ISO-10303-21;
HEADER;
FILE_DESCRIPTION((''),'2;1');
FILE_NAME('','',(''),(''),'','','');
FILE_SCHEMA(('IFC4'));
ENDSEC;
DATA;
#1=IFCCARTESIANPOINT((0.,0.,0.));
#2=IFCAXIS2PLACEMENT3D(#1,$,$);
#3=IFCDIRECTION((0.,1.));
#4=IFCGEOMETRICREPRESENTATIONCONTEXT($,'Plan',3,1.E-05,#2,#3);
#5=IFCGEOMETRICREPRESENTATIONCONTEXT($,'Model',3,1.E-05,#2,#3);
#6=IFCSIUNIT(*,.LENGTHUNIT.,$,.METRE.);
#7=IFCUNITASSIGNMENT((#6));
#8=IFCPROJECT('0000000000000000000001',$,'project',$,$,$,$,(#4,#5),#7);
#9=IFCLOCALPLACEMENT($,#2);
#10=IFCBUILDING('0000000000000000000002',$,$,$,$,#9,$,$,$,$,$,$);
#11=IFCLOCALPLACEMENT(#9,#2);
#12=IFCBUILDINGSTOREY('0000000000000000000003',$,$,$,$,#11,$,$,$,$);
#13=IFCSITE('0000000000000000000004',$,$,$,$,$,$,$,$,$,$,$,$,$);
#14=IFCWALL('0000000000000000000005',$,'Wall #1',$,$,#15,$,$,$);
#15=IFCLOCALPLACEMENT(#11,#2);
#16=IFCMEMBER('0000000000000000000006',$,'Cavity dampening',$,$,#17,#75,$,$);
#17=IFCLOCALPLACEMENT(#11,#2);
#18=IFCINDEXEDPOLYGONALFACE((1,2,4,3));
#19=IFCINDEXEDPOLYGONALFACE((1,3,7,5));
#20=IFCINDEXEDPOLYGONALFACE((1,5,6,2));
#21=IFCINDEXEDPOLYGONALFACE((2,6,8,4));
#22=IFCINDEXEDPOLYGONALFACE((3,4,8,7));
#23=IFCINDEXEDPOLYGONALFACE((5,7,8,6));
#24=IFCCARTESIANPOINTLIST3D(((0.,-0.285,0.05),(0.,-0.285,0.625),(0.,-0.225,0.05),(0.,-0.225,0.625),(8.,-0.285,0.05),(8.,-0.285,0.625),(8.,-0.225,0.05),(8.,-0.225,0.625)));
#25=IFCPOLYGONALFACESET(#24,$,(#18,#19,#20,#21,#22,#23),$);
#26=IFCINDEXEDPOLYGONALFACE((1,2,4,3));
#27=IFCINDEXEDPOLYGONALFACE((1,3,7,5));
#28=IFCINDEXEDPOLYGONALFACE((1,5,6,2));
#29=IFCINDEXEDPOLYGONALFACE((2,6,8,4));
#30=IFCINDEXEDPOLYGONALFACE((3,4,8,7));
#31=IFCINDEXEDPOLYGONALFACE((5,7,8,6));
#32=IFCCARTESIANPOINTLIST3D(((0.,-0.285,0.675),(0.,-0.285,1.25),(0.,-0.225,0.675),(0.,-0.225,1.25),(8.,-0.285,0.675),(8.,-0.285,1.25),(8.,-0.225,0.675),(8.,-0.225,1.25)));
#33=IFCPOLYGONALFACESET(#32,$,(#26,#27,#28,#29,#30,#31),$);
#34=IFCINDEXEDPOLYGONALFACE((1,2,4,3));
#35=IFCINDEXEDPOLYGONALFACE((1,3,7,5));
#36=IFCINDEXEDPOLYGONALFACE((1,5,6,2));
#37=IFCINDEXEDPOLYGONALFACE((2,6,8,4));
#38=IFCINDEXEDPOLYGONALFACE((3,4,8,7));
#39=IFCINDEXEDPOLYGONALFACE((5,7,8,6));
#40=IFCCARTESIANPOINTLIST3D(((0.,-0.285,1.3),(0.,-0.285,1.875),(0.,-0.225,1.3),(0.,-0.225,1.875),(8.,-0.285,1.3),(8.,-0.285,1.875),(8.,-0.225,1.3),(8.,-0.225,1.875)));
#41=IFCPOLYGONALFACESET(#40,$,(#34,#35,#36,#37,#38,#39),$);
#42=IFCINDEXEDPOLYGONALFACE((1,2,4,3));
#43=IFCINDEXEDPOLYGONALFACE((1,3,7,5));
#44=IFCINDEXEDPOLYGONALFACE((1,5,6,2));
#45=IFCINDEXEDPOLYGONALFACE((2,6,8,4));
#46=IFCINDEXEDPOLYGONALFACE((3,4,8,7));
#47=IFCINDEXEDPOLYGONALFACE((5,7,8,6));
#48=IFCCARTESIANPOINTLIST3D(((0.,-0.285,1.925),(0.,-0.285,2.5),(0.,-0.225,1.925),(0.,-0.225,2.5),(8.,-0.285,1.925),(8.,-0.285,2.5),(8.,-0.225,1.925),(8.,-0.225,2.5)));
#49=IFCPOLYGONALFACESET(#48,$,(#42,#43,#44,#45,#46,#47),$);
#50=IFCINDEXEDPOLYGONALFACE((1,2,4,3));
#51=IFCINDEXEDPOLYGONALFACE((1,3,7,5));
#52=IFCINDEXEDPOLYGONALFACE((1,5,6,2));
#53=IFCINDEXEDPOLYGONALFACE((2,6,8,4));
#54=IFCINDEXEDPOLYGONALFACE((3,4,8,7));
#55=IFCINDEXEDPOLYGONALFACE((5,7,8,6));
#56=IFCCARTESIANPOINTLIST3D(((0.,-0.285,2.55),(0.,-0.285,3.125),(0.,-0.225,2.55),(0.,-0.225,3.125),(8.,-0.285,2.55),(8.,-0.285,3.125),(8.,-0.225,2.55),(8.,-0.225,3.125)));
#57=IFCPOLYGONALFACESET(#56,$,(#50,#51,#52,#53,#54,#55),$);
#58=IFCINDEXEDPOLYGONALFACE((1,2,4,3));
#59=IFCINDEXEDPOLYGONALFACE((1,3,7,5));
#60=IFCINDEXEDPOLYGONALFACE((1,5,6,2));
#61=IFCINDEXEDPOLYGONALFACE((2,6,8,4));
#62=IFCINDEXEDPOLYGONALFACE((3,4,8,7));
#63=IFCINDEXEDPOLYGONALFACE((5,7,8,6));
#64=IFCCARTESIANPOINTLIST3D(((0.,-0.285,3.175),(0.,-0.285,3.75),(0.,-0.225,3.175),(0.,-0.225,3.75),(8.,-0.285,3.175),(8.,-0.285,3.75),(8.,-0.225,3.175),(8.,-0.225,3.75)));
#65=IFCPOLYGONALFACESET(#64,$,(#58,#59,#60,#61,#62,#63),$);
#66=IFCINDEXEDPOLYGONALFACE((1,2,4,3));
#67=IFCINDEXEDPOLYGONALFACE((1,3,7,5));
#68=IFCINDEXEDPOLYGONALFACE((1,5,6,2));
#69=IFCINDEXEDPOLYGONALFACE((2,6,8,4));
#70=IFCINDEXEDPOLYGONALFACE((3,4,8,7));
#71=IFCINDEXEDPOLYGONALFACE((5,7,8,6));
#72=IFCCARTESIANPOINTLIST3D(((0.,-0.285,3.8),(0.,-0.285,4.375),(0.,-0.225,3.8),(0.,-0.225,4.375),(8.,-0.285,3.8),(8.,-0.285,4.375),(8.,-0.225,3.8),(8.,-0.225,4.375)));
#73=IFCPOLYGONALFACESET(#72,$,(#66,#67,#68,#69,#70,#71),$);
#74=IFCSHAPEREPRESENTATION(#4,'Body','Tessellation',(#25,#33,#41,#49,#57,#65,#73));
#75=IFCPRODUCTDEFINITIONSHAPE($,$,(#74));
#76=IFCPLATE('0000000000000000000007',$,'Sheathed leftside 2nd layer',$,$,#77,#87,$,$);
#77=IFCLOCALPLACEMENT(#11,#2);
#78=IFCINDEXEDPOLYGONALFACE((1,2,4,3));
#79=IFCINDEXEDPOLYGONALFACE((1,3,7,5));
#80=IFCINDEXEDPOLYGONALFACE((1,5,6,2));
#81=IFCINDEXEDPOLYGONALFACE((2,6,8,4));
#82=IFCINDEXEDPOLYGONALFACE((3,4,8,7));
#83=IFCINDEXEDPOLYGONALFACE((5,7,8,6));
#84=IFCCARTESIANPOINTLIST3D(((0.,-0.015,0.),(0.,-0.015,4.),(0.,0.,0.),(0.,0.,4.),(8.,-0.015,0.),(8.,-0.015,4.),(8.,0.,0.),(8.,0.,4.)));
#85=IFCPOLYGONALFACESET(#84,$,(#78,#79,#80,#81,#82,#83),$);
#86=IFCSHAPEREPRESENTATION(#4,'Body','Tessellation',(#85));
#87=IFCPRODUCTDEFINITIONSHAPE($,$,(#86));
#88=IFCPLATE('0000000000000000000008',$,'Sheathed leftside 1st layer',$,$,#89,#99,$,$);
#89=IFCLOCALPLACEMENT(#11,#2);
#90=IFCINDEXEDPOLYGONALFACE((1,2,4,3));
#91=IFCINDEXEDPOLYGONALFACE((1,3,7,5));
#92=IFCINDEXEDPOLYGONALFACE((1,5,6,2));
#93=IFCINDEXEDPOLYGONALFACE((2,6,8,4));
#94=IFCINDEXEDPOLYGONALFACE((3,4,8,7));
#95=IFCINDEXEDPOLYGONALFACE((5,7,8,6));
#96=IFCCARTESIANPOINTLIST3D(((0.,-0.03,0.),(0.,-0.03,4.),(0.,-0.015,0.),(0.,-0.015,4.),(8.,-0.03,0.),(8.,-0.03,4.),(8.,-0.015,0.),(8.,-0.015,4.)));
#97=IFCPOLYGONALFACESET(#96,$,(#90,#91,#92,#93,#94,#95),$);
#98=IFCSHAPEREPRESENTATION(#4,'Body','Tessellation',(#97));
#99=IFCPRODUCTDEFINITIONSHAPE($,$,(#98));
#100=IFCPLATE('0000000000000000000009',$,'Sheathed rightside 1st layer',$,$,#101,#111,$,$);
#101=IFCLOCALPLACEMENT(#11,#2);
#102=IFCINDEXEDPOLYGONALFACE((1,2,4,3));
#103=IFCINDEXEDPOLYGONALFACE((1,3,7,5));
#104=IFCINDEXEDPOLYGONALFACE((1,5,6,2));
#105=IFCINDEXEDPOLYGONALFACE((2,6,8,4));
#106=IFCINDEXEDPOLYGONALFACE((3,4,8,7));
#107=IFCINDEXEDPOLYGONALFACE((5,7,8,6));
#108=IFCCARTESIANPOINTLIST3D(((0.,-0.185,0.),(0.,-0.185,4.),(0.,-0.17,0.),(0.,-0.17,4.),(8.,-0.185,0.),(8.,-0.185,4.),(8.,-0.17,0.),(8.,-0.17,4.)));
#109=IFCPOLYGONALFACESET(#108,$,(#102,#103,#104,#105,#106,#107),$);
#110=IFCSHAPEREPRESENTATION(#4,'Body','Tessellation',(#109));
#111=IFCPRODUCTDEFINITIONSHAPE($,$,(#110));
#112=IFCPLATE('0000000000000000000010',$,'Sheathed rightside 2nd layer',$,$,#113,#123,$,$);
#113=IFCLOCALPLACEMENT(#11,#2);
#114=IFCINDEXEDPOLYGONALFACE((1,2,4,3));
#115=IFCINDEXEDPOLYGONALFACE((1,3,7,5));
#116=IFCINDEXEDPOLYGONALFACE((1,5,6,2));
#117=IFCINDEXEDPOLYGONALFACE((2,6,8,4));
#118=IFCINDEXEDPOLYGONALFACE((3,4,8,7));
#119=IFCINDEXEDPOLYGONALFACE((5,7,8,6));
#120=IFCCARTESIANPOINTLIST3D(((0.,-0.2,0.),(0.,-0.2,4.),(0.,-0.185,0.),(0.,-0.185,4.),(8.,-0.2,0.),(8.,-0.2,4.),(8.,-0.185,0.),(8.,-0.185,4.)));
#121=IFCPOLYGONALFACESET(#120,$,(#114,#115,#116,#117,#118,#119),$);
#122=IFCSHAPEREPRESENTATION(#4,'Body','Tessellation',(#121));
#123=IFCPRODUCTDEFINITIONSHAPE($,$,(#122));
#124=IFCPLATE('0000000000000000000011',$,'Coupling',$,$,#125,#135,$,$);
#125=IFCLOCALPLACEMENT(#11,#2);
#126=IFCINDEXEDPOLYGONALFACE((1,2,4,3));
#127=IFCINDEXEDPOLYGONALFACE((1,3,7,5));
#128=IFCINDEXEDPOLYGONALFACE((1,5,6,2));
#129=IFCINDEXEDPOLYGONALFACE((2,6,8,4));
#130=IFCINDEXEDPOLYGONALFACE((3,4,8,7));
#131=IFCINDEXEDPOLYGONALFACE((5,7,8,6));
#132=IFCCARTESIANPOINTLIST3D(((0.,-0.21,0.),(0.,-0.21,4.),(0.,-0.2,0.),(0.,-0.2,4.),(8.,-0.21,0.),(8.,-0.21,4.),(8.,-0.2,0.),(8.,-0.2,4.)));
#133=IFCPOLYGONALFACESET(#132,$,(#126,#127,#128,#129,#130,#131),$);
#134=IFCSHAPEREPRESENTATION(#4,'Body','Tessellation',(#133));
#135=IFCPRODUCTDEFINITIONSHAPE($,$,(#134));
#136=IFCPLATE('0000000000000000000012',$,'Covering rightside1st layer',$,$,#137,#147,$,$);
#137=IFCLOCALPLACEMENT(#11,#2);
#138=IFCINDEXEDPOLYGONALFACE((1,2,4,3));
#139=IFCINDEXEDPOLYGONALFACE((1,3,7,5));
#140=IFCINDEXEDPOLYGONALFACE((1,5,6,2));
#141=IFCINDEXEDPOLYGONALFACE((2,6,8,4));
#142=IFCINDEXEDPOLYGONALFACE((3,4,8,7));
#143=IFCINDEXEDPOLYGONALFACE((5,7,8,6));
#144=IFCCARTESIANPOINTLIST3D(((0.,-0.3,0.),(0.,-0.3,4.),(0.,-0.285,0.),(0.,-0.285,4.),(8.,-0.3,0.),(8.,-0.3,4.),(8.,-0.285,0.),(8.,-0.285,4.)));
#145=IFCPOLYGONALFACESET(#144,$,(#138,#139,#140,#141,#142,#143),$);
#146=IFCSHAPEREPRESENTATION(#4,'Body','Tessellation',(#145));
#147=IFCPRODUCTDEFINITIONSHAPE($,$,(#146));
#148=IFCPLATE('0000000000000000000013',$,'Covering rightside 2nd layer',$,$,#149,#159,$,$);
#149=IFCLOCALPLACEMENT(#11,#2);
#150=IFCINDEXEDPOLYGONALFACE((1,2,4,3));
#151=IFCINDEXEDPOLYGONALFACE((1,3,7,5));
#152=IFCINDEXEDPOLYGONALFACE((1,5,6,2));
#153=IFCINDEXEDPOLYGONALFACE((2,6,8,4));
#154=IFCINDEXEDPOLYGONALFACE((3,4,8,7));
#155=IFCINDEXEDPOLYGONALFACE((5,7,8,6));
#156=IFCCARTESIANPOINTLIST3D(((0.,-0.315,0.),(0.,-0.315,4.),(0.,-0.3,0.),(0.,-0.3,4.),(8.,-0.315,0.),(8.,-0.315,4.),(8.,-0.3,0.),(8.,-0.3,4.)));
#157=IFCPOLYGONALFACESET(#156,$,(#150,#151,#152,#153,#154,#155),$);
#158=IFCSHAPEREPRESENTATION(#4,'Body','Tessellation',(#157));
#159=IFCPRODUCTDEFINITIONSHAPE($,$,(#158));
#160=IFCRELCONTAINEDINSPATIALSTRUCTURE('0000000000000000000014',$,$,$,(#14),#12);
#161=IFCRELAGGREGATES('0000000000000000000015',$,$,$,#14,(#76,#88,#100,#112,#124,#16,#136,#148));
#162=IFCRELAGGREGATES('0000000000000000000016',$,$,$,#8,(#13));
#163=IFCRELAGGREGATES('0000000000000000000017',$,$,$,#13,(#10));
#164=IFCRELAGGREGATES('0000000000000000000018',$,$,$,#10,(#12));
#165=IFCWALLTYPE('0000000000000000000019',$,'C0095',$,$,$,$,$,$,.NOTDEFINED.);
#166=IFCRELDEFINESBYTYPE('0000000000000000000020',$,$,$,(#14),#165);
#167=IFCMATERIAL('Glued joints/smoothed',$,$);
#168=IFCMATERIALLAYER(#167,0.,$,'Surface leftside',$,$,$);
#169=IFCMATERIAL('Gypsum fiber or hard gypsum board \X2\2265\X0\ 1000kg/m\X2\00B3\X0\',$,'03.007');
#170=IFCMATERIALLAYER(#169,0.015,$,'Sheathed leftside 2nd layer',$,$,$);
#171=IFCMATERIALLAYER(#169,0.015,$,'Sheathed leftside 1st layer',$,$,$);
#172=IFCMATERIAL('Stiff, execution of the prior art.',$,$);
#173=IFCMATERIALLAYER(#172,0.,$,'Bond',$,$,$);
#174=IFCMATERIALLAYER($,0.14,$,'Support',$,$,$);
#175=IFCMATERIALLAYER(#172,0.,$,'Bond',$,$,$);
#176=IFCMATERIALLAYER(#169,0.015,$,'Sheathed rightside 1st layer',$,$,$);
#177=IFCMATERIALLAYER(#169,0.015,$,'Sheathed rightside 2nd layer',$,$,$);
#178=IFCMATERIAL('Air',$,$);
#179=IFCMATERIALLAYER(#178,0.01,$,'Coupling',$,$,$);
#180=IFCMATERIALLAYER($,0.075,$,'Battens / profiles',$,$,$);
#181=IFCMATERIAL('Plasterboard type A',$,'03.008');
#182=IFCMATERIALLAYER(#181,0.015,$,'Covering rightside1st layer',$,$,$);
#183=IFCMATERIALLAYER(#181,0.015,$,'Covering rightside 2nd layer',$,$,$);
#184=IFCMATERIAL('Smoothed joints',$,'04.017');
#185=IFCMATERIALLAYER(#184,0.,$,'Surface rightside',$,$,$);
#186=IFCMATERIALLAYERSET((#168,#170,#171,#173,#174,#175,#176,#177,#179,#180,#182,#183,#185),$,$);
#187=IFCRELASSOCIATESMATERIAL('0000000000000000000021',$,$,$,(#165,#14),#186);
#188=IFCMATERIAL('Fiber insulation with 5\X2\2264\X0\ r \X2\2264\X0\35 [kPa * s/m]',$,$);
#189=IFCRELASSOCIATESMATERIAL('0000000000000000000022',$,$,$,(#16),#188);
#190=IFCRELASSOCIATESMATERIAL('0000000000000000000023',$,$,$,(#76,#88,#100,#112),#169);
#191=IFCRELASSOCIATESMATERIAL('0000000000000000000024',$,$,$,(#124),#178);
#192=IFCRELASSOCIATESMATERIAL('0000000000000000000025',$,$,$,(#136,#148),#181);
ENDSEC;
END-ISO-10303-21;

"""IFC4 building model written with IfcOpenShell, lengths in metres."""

from ifc_helpers import new_model, si_unit, direction, frame, frame_2d, origin, origin_with_axes, place, context, project, spatial, rectangle, extrude, material, layer, layer_set, type_object, element, aggregate, save


model = new_model("IFC4")

# Units and contexts
plan_context = context("Plan", 3, precision=1e-05, world=origin(), true_north=direction((0.0, 1.0)))
model_context = context("Model", 3, precision=1e-05, world=origin(), true_north=direction((0.0, 1.0)))
ifc_project = project(units=[si_unit("LENGTHUNIT", "METRE")], contexts=[plan_context, model_context])

# Site, building, storey
site = spatial("IfcSite", under=ifc_project)
building_placement = place(None, origin())
building = spatial("IfcBuilding", under=site, at=building_placement)
storey_placement = place(building_placement, origin())
storey = spatial("IfcBuildingStorey", under=building, at=storey_placement)

# Wall, member, plates
ifc_material_1 = material(Name="Glued joints/smoothed")
ifc_layer_1 = layer(ifc_material_1, 0.0, Name="Surface leftside")
ifc_material_2 = material(Name="Gypsum fiber or hard gypsum board ≥ 1000kg/m³", Category="03.007")
ifc_layer_2 = layer(ifc_material_2, 0.015, Name="Sheathed leftside 2nd layer")
ifc_layer_3 = layer(ifc_material_2, 0.015, Name="Sheathed leftside 1st layer")
ifc_material_3 = material(Name="Stiff, execution of the prior art.")
ifc_layer_4 = layer(ifc_material_3, 0.0, Name="Bond")
ifc_layer_5 = layer(None, 0.14, Name="Support")
ifc_layer_6 = layer(ifc_material_3, 0.0, Name="Bond")
ifc_layer_7 = layer(ifc_material_2, 0.015, Name="Sheathed rightside 1st layer")
ifc_layer_8 = layer(ifc_material_2, 0.015, Name="Sheathed rightside 2nd layer")
ifc_material_4 = material(Name="Air")
ifc_layer_9 = layer(ifc_material_4, 0.01, Name="Coupling")
ifc_layer_10 = layer(None, 0.075, Name="Battens / profiles")
ifc_material_5 = material(Name="Plasterboard type A", Category="03.008")
ifc_layer_11 = layer(ifc_material_5, 0.015, Name="Covering rightside1st layer")
ifc_layer_12 = layer(ifc_material_5, 0.015, Name="Covering rightside 2nd layer")
ifc_material_6 = material(Name="Smoothed joints", Category="04.017")
ifc_layer_13 = layer(ifc_material_6, 0.0, Name="Surface rightside")
ifc_layer_set = layer_set([ifc_layer_1, ifc_layer_2, ifc_layer_3, ifc_layer_4, ifc_layer_5, ifc_layer_6, ifc_layer_7, ifc_layer_8, ifc_layer_9, ifc_layer_10, ifc_layer_11, ifc_layer_12, ifc_layer_13])
wall_type = type_object("IfcWallType", Name="C0095", PredefinedType="NOTDEFINED", material=ifc_layer_set)
wall_placement = place(None, frame((0.0, 0.0, 0.0), z_axis=(0.0, -1.0, 0.0), x_axis=(1.0, 0.0, 0.0)))
wall = element("IfcWall", 1, at=wall_placement, inside=storey, type_object=wall_type, material=ifc_layer_set, Name="Wall #1")
ifc_material_7 = material(Name="Fiber insulation with 5≤ r ≤35 [kPa * s/m]")
member_1_placement = place(wall_placement, origin())
member_1 = element("IfcMember", 2, at=member_1_placement, material=ifc_material_7, Name="Cavity dampening", context=plan_context, shape_type="SweptSolid", body=[
    extrude(rectangle(XDim=0.575, YDim=0.06, at=frame_2d((0.2875, 0.03), x_axis=(1.0, 0.0))), frame((0.0, 0.05, 0.225), z_axis=(1.0, 0.0, 0.0), x_axis=(0.0, 1.0, 0.0)), (0.0, 0.0, 1.0), 8.0),
    extrude(rectangle(XDim=0.575, YDim=0.06, at=frame_2d((0.2875, 0.03), x_axis=(1.0, 0.0))), frame((0.0, 0.675, 0.225), z_axis=(1.0, 0.0, 0.0), x_axis=(0.0, 1.0, 0.0)), (0.0, 0.0, 1.0), 8.0),
    extrude(rectangle(XDim=0.575, YDim=0.06, at=frame_2d((0.2875, 0.03), x_axis=(1.0, 0.0))), frame((0.0, 1.3, 0.225), z_axis=(1.0, 0.0, 0.0), x_axis=(0.0, 1.0, 0.0)), (0.0, 0.0, 1.0), 8.0),
    extrude(rectangle(XDim=0.575, YDim=0.06, at=frame_2d((0.2875, 0.03), x_axis=(1.0, 0.0))), frame((0.0, 1.925, 0.225), z_axis=(1.0, 0.0, 0.0), x_axis=(0.0, 1.0, 0.0)), (0.0, 0.0, 1.0), 8.0),
    extrude(rectangle(XDim=0.575, YDim=0.06, at=frame_2d((0.2875, 0.03), x_axis=(1.0, 0.0))), frame((0.0, 2.55, 0.225), z_axis=(1.0, 0.0, 0.0), x_axis=(0.0, 1.0, 0.0)), (0.0, 0.0, 1.0), 8.0),
    extrude(rectangle(XDim=0.575, YDim=0.06, at=frame_2d((0.2875, 0.03), x_axis=(1.0, 0.0))), frame((0.0, 3.175, 0.225), z_axis=(1.0, 0.0, 0.0), x_axis=(0.0, 1.0, 0.0)), (0.0, 0.0, 1.0), 8.0),
    extrude(rectangle(XDim=0.575, YDim=0.06, at=frame_2d((0.2875, 0.03), x_axis=(1.0, 0.0))), frame((0.0, 3.8, 0.225), z_axis=(1.0, 0.0, 0.0), x_axis=(0.0, 1.0, 0.0)), (0.0, 0.0, 1.0), 8.0),
])
plate_1_placement = place(wall_placement, origin())
plate_1 = element("IfcPlate", 3, at=plate_1_placement, material=ifc_material_2, Name="Sheathed leftside 2nd layer", context=plan_context, shape_type="SweptSolid", body=[
    extrude(rectangle(XDim=8.0, YDim=4.0, at=frame_2d((4.0, 2.0), x_axis=(1.0, 0.0))), origin_with_axes(), (0.0, 0.0, 1.0), 0.015),
])
plate_2_placement = place(wall_placement, origin())
plate_2 = element("IfcPlate", 4, at=plate_2_placement, material=ifc_material_2, Name="Sheathed leftside 1st layer", context=plan_context, shape_type="SweptSolid", body=[
    extrude(rectangle(XDim=8.0, YDim=4.0, at=frame_2d((4.0, 2.0), x_axis=(1.0, 0.0))), frame((0.0, 0.0, 0.015), z_axis=(0.0, 0.0, 1.0), x_axis=(1.0, 0.0, 0.0)), (0.0, 0.0, 1.0), 0.015),
])
plate_3_placement = place(wall_placement, origin())
plate_3 = element("IfcPlate", 5, at=plate_3_placement, material=ifc_material_2, Name="Sheathed rightside 1st layer", context=plan_context, shape_type="SweptSolid", body=[
    extrude(rectangle(XDim=8.0, YDim=4.0, at=frame_2d((4.0, 2.0), x_axis=(1.0, 0.0))), frame((0.0, 0.0, 0.17), z_axis=(0.0, 0.0, 1.0), x_axis=(1.0, 0.0, 0.0)), (0.0, 0.0, 1.0), 0.015),
])
plate_4_placement = place(wall_placement, origin())
plate_4 = element("IfcPlate", 6, at=plate_4_placement, material=ifc_material_2, Name="Sheathed rightside 2nd layer", context=plan_context, shape_type="SweptSolid", body=[
    extrude(rectangle(XDim=8.0, YDim=4.0, at=frame_2d((4.0, 2.0), x_axis=(1.0, 0.0))), frame((0.0, 0.0, 0.185), z_axis=(0.0, 0.0, 1.0), x_axis=(1.0, 0.0, 0.0)), (0.0, 0.0, 1.0), 0.015),
])
plate_5_placement = place(wall_placement, origin())
plate_5 = element("IfcPlate", 7, at=plate_5_placement, material=ifc_material_4, Name="Coupling", context=plan_context, shape_type="SweptSolid", body=[
    extrude(rectangle(XDim=8.0, YDim=4.0, at=frame_2d((4.0, 2.0), x_axis=(1.0, 0.0))), frame((0.0, 0.0, 0.2), z_axis=(0.0, 0.0, 1.0), x_axis=(1.0, 0.0, 0.0)), (0.0, 0.0, 1.0), 0.01),
])
plate_6_placement = place(wall_placement, origin())
plate_6 = element("IfcPlate", 8, at=plate_6_placement, material=ifc_material_5, Name="Covering rightside1st layer", context=plan_context, shape_type="SweptSolid", body=[
    extrude(rectangle(XDim=8.0, YDim=4.0, at=frame_2d((4.0, 2.0), x_axis=(1.0, 0.0))), frame((0.0, 0.0, 0.285), z_axis=(0.0, 0.0, 1.0), x_axis=(1.0, 0.0, 0.0)), (0.0, 0.0, 1.0), 0.015),
])
plate_7_placement = place(wall_placement, origin())
plate_7 = element("IfcPlate", 9, at=plate_7_placement, material=ifc_material_5, Name="Covering rightside 2nd layer", context=plan_context, shape_type="SweptSolid", body=[
    extrude(rectangle(XDim=8.0, YDim=4.0, at=frame_2d((4.0, 2.0), x_axis=(1.0, 0.0))), frame((0.0, 0.0, 0.3), z_axis=(0.0, 0.0, 1.0), x_axis=(1.0, 0.0, 0.0)), (0.0, 0.0, 1.0), 0.015),
])
aggregate(wall, [plate_1, plate_2, plate_3, plate_4, plate_5, member_1, plate_6, plate_7])

save(model, "model.ifc")
